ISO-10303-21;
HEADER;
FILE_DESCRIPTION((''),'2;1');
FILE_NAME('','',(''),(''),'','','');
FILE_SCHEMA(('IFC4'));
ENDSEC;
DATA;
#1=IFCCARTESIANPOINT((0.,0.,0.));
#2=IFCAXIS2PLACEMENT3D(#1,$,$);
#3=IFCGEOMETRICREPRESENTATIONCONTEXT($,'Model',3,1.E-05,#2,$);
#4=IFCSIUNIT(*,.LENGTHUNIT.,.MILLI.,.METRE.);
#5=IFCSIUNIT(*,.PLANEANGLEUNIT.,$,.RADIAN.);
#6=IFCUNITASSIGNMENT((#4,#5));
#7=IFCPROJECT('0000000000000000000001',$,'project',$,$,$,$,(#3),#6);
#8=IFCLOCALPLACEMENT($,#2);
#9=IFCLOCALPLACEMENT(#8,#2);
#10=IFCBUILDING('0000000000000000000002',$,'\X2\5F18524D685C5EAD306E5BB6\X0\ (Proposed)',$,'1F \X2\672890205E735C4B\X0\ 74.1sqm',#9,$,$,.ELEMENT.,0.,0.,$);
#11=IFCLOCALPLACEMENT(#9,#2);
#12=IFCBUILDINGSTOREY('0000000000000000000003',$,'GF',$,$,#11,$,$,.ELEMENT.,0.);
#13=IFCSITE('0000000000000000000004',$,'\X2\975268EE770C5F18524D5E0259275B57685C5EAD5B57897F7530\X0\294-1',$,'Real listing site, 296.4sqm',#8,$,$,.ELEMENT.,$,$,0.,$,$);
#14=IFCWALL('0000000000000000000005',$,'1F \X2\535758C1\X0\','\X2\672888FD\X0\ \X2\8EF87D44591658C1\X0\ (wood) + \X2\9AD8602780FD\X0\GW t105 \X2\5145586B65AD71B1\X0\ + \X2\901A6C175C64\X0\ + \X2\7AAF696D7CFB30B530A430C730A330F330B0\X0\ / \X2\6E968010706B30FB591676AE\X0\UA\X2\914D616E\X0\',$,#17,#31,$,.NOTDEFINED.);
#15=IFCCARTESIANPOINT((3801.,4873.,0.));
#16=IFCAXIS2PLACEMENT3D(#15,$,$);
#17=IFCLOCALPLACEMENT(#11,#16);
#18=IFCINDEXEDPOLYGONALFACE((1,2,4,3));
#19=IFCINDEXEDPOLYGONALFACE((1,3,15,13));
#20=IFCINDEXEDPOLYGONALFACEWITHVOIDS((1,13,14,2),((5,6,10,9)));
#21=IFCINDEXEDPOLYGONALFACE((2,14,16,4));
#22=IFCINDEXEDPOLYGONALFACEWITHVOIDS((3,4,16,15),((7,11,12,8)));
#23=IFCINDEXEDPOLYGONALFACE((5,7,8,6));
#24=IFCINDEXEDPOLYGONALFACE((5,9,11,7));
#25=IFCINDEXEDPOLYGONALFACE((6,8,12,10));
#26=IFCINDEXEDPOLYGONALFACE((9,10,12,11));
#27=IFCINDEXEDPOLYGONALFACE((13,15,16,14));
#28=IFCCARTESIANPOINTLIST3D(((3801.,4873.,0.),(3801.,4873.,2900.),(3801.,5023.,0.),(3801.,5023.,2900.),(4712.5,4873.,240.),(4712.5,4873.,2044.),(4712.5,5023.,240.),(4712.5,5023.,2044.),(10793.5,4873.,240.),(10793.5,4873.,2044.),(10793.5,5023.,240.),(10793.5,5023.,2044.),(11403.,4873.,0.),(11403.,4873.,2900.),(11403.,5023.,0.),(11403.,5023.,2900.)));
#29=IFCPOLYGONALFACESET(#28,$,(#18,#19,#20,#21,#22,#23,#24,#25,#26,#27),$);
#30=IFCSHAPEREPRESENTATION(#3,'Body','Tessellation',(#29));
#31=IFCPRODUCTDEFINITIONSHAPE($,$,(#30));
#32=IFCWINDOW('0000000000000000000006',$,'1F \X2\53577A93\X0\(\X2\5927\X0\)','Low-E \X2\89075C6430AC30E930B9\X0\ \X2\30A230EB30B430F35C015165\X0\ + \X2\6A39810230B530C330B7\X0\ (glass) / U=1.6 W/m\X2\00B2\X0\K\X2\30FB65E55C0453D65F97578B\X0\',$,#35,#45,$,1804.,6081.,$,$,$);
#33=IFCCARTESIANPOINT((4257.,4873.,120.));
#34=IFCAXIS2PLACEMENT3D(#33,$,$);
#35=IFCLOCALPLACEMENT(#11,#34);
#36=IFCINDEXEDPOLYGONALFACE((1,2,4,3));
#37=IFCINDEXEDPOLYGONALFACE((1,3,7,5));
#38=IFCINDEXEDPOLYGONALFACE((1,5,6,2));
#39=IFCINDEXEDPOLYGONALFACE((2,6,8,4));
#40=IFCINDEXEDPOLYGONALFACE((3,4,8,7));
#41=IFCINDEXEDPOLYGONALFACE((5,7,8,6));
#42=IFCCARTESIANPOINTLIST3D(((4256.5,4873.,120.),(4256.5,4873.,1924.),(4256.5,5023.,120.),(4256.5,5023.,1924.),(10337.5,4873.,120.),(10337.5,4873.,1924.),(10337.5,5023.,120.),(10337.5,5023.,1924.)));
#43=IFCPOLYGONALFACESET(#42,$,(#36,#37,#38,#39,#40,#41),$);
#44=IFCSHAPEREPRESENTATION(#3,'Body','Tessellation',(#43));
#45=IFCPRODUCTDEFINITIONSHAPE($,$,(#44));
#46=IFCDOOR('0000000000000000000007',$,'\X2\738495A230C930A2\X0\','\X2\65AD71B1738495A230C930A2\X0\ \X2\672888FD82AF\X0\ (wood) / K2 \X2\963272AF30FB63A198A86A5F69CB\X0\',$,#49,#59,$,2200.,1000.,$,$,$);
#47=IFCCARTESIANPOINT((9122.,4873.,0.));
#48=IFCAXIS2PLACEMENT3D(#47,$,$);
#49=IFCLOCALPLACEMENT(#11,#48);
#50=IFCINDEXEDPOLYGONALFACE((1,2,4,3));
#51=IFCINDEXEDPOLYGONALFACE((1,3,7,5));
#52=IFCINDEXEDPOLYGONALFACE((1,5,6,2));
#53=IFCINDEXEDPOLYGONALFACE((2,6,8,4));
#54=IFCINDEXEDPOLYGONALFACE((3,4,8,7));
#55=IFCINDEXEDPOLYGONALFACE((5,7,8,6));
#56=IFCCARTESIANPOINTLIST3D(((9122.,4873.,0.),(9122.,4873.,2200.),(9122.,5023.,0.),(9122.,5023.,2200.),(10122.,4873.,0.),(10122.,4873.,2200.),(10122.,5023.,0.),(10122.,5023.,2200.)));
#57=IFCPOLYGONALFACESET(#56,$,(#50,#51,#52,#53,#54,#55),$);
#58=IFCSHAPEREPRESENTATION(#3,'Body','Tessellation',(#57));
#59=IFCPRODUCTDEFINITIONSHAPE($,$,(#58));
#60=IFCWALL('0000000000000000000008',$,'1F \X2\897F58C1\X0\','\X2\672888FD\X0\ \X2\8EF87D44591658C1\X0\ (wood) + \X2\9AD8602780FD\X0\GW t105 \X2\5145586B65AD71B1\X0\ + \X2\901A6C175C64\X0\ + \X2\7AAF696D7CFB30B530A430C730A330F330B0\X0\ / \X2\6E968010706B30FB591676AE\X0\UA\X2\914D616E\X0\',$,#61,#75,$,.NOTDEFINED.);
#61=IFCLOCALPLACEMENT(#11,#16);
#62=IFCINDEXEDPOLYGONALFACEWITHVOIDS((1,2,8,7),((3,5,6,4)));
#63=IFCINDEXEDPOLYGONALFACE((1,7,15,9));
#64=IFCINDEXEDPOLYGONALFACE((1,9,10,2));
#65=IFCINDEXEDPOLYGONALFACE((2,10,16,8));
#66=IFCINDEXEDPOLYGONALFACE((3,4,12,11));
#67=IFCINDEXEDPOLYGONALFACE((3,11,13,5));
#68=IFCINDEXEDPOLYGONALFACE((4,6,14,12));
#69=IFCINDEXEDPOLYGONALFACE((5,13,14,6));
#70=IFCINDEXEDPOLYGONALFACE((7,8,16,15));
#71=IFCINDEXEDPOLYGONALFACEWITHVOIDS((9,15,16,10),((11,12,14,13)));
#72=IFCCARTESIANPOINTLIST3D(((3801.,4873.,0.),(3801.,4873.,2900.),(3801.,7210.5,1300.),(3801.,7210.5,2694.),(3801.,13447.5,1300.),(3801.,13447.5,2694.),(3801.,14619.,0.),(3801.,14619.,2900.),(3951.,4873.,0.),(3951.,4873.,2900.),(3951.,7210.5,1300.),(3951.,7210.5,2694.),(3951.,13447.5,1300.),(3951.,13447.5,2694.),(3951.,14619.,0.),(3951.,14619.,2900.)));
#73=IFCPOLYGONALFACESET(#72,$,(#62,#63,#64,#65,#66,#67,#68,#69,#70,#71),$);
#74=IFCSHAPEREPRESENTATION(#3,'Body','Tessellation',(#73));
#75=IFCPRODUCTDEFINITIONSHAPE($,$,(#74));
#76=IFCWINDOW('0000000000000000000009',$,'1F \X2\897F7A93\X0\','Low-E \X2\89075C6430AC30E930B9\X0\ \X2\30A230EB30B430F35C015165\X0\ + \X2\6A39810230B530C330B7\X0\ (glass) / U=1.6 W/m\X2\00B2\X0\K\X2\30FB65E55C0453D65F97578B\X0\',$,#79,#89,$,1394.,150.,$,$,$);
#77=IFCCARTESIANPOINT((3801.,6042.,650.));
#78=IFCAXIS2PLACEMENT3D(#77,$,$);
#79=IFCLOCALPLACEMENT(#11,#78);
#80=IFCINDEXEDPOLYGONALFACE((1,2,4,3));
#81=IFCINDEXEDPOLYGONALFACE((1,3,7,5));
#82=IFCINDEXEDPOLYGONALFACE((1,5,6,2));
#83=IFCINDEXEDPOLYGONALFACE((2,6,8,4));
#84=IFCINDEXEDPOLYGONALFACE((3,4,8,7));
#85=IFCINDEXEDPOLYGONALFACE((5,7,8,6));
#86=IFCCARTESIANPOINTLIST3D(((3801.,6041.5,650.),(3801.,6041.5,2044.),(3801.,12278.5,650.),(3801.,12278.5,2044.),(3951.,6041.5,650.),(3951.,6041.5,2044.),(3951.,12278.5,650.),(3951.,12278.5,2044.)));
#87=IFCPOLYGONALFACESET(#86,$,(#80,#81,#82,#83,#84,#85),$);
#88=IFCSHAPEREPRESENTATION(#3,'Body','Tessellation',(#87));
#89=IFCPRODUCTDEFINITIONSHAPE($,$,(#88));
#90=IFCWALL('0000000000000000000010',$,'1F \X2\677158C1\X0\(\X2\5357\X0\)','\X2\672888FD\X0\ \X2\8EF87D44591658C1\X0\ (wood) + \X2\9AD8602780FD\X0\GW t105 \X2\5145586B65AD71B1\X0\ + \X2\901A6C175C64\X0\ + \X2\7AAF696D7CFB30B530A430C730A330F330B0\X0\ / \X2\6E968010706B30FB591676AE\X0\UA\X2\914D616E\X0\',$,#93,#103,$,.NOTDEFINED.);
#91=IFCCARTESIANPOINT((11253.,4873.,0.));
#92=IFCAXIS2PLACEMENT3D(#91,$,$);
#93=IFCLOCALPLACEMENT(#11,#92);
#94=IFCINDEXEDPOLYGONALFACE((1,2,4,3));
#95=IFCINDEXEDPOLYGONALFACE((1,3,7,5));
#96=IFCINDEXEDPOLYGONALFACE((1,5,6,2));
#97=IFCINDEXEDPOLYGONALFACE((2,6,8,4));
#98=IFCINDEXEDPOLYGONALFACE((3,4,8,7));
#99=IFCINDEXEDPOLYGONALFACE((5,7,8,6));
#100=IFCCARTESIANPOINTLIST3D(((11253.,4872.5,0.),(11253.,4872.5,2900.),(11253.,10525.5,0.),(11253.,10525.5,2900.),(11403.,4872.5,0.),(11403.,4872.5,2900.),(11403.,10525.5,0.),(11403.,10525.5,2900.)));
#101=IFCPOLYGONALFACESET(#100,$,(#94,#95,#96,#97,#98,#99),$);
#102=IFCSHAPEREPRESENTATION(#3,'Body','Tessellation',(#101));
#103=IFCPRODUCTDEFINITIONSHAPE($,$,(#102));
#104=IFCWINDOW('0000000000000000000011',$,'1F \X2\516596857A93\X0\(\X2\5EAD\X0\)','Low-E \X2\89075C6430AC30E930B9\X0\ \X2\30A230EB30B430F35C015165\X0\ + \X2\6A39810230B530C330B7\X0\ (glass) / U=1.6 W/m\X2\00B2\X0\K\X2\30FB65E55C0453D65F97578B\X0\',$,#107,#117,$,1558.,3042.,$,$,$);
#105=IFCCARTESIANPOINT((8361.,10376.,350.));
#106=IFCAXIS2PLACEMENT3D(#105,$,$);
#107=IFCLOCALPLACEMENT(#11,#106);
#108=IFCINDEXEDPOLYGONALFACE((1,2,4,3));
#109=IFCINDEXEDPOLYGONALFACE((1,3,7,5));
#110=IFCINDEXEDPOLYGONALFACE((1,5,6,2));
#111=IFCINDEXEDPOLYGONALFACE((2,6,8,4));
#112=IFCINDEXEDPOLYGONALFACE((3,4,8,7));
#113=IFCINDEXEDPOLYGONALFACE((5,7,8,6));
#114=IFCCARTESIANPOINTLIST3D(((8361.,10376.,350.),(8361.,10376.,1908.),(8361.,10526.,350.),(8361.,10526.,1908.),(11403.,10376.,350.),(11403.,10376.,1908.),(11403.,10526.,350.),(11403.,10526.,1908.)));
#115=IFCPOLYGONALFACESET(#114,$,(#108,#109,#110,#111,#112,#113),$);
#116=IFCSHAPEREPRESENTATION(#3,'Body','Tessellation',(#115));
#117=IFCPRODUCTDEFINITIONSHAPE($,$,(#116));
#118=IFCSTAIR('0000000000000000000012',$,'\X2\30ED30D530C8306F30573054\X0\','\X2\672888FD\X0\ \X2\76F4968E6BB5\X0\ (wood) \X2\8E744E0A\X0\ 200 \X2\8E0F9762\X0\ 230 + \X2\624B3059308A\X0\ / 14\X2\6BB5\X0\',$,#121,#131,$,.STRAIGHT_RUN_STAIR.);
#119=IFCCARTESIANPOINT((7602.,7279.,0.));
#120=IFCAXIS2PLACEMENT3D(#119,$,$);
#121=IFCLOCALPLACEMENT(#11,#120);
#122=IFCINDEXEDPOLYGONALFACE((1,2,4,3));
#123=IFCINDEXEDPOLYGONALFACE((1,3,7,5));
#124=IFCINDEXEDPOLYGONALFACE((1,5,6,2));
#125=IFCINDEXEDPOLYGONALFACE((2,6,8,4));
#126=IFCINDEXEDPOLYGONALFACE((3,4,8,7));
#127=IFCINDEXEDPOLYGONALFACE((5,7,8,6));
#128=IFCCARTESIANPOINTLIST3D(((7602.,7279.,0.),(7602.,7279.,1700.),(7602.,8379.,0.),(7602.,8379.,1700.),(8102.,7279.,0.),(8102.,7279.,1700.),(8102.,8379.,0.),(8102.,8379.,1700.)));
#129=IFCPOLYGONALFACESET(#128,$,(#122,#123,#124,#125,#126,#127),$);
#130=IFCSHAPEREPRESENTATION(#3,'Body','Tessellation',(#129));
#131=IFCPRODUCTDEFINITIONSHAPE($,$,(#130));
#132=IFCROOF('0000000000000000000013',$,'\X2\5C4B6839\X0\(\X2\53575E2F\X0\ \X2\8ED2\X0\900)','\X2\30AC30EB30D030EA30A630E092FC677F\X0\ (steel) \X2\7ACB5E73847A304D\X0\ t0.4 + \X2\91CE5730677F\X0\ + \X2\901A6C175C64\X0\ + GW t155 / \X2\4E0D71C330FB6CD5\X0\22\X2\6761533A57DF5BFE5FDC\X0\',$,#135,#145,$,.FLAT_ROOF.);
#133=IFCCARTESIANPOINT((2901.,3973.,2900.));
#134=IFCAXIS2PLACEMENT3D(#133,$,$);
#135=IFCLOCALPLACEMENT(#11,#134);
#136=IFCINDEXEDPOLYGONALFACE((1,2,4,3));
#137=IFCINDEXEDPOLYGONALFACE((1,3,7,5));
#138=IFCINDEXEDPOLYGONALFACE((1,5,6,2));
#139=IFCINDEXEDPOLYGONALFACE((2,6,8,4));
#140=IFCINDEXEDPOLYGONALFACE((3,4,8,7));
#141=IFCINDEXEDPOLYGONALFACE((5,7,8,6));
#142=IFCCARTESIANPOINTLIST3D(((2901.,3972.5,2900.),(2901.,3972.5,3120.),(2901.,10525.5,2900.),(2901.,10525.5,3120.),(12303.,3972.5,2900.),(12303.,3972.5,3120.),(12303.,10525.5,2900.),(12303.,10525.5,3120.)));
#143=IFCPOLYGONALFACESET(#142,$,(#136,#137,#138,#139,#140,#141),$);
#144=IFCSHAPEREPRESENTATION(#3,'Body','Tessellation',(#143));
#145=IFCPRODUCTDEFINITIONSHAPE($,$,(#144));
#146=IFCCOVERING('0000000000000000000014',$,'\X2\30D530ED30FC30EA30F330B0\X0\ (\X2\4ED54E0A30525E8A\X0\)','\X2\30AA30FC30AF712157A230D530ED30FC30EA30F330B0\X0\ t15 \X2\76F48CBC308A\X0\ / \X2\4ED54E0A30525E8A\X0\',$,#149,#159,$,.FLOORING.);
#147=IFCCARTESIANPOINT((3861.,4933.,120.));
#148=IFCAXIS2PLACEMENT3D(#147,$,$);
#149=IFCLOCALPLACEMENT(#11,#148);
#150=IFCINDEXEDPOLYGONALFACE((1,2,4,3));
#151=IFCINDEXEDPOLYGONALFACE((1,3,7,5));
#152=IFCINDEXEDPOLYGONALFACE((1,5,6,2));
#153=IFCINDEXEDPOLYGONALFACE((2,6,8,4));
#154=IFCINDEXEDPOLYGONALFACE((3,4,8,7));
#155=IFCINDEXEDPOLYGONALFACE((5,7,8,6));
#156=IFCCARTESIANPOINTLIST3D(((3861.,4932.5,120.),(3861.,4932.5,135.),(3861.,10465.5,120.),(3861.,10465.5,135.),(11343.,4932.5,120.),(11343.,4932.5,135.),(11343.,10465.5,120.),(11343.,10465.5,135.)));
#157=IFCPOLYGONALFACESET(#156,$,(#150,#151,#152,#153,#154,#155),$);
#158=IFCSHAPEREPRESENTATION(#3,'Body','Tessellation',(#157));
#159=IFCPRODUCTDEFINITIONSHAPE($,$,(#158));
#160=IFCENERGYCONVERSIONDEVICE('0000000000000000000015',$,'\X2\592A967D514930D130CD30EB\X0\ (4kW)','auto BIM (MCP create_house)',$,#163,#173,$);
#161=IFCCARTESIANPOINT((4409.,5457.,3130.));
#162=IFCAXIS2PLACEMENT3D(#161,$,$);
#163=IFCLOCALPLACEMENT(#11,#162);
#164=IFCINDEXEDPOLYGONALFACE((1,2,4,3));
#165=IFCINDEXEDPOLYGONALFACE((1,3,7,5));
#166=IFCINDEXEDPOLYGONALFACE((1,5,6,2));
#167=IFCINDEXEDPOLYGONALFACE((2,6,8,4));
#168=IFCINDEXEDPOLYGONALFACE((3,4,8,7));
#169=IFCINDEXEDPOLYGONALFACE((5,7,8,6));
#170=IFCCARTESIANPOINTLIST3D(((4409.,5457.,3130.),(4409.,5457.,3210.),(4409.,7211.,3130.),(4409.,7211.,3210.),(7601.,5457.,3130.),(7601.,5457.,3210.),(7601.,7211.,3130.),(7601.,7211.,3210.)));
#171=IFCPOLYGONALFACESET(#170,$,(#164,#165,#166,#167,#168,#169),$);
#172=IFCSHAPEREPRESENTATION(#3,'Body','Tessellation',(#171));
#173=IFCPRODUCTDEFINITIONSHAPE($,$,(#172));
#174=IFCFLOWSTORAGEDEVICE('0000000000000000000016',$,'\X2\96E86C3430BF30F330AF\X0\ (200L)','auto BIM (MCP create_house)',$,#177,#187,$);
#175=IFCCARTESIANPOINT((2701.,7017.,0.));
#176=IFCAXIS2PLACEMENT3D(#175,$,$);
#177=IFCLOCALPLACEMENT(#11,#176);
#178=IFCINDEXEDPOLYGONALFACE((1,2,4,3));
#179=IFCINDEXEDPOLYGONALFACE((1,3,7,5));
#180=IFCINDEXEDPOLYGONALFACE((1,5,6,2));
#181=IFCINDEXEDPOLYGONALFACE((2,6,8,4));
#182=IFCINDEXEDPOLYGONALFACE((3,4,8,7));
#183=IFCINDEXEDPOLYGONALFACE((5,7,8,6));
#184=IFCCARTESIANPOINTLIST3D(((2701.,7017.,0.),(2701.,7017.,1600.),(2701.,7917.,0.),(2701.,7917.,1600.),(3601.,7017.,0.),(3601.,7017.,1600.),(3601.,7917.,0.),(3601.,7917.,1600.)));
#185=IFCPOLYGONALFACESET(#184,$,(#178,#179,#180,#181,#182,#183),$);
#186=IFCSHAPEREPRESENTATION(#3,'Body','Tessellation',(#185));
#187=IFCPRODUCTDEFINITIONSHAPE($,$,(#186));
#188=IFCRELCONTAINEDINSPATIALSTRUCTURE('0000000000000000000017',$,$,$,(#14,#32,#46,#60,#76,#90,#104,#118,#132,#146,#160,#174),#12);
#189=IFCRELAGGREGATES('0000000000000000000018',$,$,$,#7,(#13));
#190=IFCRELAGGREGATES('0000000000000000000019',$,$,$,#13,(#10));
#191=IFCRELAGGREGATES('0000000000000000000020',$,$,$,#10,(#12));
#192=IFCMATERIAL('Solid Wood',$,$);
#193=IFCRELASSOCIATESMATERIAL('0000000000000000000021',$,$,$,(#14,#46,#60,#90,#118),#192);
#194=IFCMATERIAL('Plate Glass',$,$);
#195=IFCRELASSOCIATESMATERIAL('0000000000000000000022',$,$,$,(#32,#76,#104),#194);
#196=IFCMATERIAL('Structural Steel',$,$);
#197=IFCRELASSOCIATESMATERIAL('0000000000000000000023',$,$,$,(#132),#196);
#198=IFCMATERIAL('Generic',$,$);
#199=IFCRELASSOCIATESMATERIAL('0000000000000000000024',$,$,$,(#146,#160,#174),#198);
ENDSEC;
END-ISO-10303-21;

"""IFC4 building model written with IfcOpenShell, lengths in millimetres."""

from ifc_helpers import new_model, si_unit, frame, frame_2d, origin, place, context, project, spatial, rectangle, extrude, material, element, fill, save


model = new_model("IFC4")

# Units and contexts
model_context = context("Model", 3, precision=1e-05, world=origin())
ifc_project = project(units=[si_unit("LENGTHUNIT", "METRE", prefix="MILLI"), si_unit("PLANEANGLEUNIT", "RADIAN")], contexts=[model_context])

# Site, building, storey
site_placement = place(None, origin())
site = spatial("IfcSite", under=ifc_project, at=site_placement, Name="青森県弘前市大字桜庭字西田294-1", ObjectType="Real listing site, 296.4sqm", CompositionType="ELEMENT", RefElevation=0.0)
building_placement = place(site_placement, origin())
building = spatial("IfcBuilding", under=site, at=building_placement, Name="弘前桜庭の家 (Proposed)", ObjectType="1F 木造平屋 74.1sqm", CompositionType="ELEMENT", ElevationOfRefHeight=0.0, ElevationOfTerrain=0.0)
storey_placement = place(building_placement, origin())
storey = spatial("IfcBuildingStorey", under=building, at=storey_placement, Name="GF", CompositionType="ELEMENT", Elevation=0.0)

# Shared definitions
ifc_material_1 = material(Name="Solid Wood")

# Wall, openings, window, door
wall_1_placement = place(storey_placement, frame((3801.0, 4873.0, 0.0)))
wall_1 = element("IfcWall", 1, at=wall_1_placement, inside=storey, material=ifc_material_1, Name="1F 南壁", Description="木製 軸組外壁 (wood) + 高性能GW t105 充填断熱 + 通気層 + 窯業系サイディング / 準耐火・外皮UA配慮", PredefinedType="NOTDEFINED", context=model_context, shape_type="SweptSolid", body=[
    extrude(rectangle(XDim=7602.0, YDim=150.0, at=frame_2d((3801.0, 75.0))), frame((3801.0, 4873.0, 0.0)), (0.0, 0.0, 1.0), 2900.0),
])
opening_1_placement = place(storey_placement, frame((4257.0, 4873.0, 120.0)))
opening_1 = element("IfcOpeningElement", 2, at=opening_1_placement, cuts=wall_1, PredefinedType="NOTDEFINED", context=model_context, shape_type="SweptSolid", body=[
    extrude(rectangle(XDim=6081.0, YDim=150.0, at=frame_2d((3040.0, 75.0))), frame((4257.0, 4873.0, 120.0)), (0.0, 0.0, 1.0), 1804.0),
])
opening_2_placement = place(storey_placement, frame((9122.0, 4873.0, 0.0)))
opening_2 = element("IfcOpeningElement", 3, at=opening_2_placement, cuts=wall_1, PredefinedType="NOTDEFINED", context=model_context, shape_type="SweptSolid", body=[
    extrude(rectangle(XDim=1000.0, YDim=150.0, at=frame_2d((500.0, 75.0))), frame((9122.0, 4873.0, 0.0)), (0.0, 0.0, 1.0), 2200.0),
])
ifc_material_2 = material(Name="Plate Glass")
window_1_placement = place(storey_placement, frame((4257.0, 4873.0, 120.0)))
window_1 = element("IfcWindow", 4, at=window_1_placement, inside=storey, material=ifc_material_2, Name="1F 南窓(大)", Description="Low-E 複層ガラス アルゴン封入 + 樹脂サッシ (glass) / U=1.6 W/m²K・日射取得型", OverallHeight=1804.0, OverallWidth=6081.0, context=model_context, shape_type="SweptSolid", body=[
    extrude(rectangle(XDim=6081.0, YDim=150.0, at=frame_2d((3040.0, 75.0))), frame((4257.0, 4873.0, 120.0)), (0.0, 0.0, 1.0), 1804.0),
])
fill(opening_1, window_1)
door_1_placement = place(storey_placement, frame((9122.0, 4873.0, 0.0)))
door_1 = element("IfcDoor", 5, at=door_1_placement, inside=storey, material=ifc_material_1, Name="玄関ドア", Description="断熱玄関ドア 木製芯 (wood) / K2 防犯・採風機構", OverallHeight=2200.0, OverallWidth=1000.0, context=model_context, shape_type="SweptSolid", body=[
    extrude(rectangle(XDim=1000.0, YDim=150.0, at=frame_2d((500.0, 75.0))), frame((9122.0, 4873.0, 0.0)), (0.0, 0.0, 1.0), 2200.0),
])
fill(opening_2, door_1)

# Walls, openings, windows
wall_2_placement = place(storey_placement, frame((3801.0, 4873.0, 0.0)))
wall_2 = element("IfcWall", 6, at=wall_2_placement, inside=storey, material=ifc_material_1, Name="1F 西壁", Description="木製 軸組外壁 (wood) + 高性能GW t105 充填断熱 + 通気層 + 窯業系サイディング / 準耐火・外皮UA配慮", PredefinedType="NOTDEFINED", context=model_context, shape_type="SweptSolid", body=[
    extrude(rectangle(XDim=150.0, YDim=9746.0, at=frame_2d((75.0, 4873.0))), frame((3801.0, 4873.0, 0.0)), (0.0, 0.0, 1.0), 2900.0),
])
opening_3_placement = place(storey_placement, frame((3801.0, 6042.0, 650.0)))
opening_3 = element("IfcOpeningElement", 7, at=opening_3_placement, cuts=wall_2, PredefinedType="NOTDEFINED", context=model_context, shape_type="SweptSolid", body=[
    extrude(rectangle(XDim=150.0, YDim=6237.0, at=frame_2d((75.0, 3118.0))), frame((3801.0, 6042.0, 650.0)), (0.0, 0.0, 1.0), 1394.0),
])
window_2_placement = place(storey_placement, frame((3801.0, 6042.0, 650.0)))
window_2 = element("IfcWindow", 8, at=window_2_placement, inside=storey, material=ifc_material_2, Name="1F 西窓", Description="Low-E 複層ガラス アルゴン封入 + 樹脂サッシ (glass) / U=1.6 W/m²K・日射取得型", OverallHeight=1394.0, OverallWidth=150.0, context=model_context, shape_type="SweptSolid", body=[
    extrude(rectangle(XDim=150.0, YDim=6237.0, at=frame_2d((75.0, 3118.0))), frame((3801.0, 6042.0, 650.0)), (0.0, 0.0, 1.0), 1394.0),
])
fill(opening_3, window_2)
wall_3_placement = place(storey_placement, frame((11253.0, 4873.0, 0.0)))
wall_3 = element("IfcWall", 9, at=wall_3_placement, inside=storey, material=ifc_material_1, Name="1F 東壁(南)", Description="木製 軸組外壁 (wood) + 高性能GW t105 充填断熱 + 通気層 + 窯業系サイディング / 準耐火・外皮UA配慮", PredefinedType="NOTDEFINED", context=model_context, shape_type="SweptSolid", body=[
    extrude(rectangle(XDim=150.0, YDim=5653.0, at=frame_2d((75.0, 2826.0))), frame((11253.0, 4873.0, 0.0)), (0.0, 0.0, 1.0), 2900.0),
])
opening_4_placement = place(storey_placement, frame((8361.0, 10376.0, 350.0)))
opening_4 = element("IfcOpeningElement", 10, at=opening_4_placement, cuts=wall_3, PredefinedType="NOTDEFINED", context=model_context, shape_type="SweptSolid", body=[
    extrude(rectangle(XDim=3042.0, YDim=150.0, at=frame_2d((1521.0, 75.0))), frame((8361.0, 10376.0, 350.0)), (0.0, 0.0, 1.0), 1558.0),
])
window_3_placement = place(storey_placement, frame((8361.0, 10376.0, 350.0)))
window_3 = element("IfcWindow", 11, at=window_3_placement, inside=storey, material=ifc_material_2, Name="1F 入隅窓(庭)", Description="Low-E 複層ガラス アルゴン封入 + 樹脂サッシ (glass) / U=1.6 W/m²K・日射取得型", OverallHeight=1558.0, OverallWidth=3042.0, context=model_context, shape_type="SweptSolid", body=[
    extrude(rectangle(XDim=3042.0, YDim=150.0, at=frame_2d((1521.0, 75.0))), frame((8361.0, 10376.0, 350.0)), (0.0, 0.0, 1.0), 1558.0),
])
fill(opening_4, window_3)

# Stair
stair_placement = place(storey_placement, frame((7602.0, 7279.0, 0.0)))
element("IfcStair", 12, at=stair_placement, inside=storey, material=ifc_material_1, Name="ロフトはしご", Description="木製 直階段 (wood) 蹴上 200 踏面 230 + 手すり / 14段", PredefinedType="STRAIGHT_RUN_STAIR", context=model_context, shape_type="SweptSolid", body=[
    extrude(rectangle(XDim=500.0, YDim=1100.0, at=frame_2d((250.0, 550.0))), frame((7602.0, 7279.0, 0.0)), (0.0, 0.0, 1.0), 1700.0),
])

# Roof
ifc_material_3 = material(Name="Structural Steel")
roof_placement = place(storey_placement, frame((2901.0, 3973.0, 2900.0)))
element("IfcRoof", 13, at=roof_placement, inside=storey, material=ifc_material_3, Name="屋根(南帯 軒900)", Description="ガルバリウム鋼板 (steel) 立平葺き t0.4 + 野地板 + 通気層 + GW t155 / 不燃・法22条区域対応", PredefinedType="FLAT_ROOF", context=model_context, shape_type="SweptSolid", body=[
    extrude(rectangle(XDim=9402.0, YDim=6553.0, at=frame_2d((4701.0, 3276.0))), frame((2901.0, 3973.0, 2900.0)), (0.0, 0.0, 1.0), 220.0),
])

# Covering
ifc_material_4 = material(Name="Generic")
covering_placement = place(storey_placement, frame((3861.0, 4933.0, 120.0)))
element("IfcCovering", 14, at=covering_placement, inside=storey, material=ifc_material_4, Name="フローリング (仕上げ床)", Description="オーク無垢フローリング t15 直貼り / 仕上げ床", PredefinedType="FLOORING", context=model_context, shape_type="SweptSolid", body=[
    extrude(rectangle(XDim=7482.0, YDim=5533.0, at=frame_2d((3741.0, 2766.0))), frame((3861.0, 4933.0, 120.0)), (0.0, 0.0, 1.0), 15.0),
])

# Energy conversion device
energy_conversion_device_placement = place(storey_placement, frame((4409.0, 5457.0, 3130.0)))
element("IfcEnergyConversionDevice", 15, at=energy_conversion_device_placement, inside=storey, material=ifc_material_4, Name="太陽光パネル (4kW)", Description="auto BIM (MCP create_house)", context=model_context, shape_type="SweptSolid", body=[
    extrude(rectangle(XDim=3192.0, YDim=1754.0, at=frame_2d((1596.0, 877.0))), frame((4409.0, 5457.0, 3130.0)), (0.0, 0.0, 1.0), 80.0),
])

# Flow storage device
flow_storage_device_placement = place(storey_placement, frame((2701.0, 7017.0, 0.0)))
element("IfcFlowStorageDevice", 16, at=flow_storage_device_placement, inside=storey, material=ifc_material_4, Name="雨水タンク (200L)", Description="auto BIM (MCP create_house)", context=model_context, shape_type="SweptSolid", body=[
    extrude(rectangle(XDim=900.0, YDim=900.0, at=frame_2d((450.0, 450.0))), frame((2701.0, 7017.0, 0.0)), (0.0, 0.0, 1.0), 1600.0),
])

save(model, "model.ifc")
